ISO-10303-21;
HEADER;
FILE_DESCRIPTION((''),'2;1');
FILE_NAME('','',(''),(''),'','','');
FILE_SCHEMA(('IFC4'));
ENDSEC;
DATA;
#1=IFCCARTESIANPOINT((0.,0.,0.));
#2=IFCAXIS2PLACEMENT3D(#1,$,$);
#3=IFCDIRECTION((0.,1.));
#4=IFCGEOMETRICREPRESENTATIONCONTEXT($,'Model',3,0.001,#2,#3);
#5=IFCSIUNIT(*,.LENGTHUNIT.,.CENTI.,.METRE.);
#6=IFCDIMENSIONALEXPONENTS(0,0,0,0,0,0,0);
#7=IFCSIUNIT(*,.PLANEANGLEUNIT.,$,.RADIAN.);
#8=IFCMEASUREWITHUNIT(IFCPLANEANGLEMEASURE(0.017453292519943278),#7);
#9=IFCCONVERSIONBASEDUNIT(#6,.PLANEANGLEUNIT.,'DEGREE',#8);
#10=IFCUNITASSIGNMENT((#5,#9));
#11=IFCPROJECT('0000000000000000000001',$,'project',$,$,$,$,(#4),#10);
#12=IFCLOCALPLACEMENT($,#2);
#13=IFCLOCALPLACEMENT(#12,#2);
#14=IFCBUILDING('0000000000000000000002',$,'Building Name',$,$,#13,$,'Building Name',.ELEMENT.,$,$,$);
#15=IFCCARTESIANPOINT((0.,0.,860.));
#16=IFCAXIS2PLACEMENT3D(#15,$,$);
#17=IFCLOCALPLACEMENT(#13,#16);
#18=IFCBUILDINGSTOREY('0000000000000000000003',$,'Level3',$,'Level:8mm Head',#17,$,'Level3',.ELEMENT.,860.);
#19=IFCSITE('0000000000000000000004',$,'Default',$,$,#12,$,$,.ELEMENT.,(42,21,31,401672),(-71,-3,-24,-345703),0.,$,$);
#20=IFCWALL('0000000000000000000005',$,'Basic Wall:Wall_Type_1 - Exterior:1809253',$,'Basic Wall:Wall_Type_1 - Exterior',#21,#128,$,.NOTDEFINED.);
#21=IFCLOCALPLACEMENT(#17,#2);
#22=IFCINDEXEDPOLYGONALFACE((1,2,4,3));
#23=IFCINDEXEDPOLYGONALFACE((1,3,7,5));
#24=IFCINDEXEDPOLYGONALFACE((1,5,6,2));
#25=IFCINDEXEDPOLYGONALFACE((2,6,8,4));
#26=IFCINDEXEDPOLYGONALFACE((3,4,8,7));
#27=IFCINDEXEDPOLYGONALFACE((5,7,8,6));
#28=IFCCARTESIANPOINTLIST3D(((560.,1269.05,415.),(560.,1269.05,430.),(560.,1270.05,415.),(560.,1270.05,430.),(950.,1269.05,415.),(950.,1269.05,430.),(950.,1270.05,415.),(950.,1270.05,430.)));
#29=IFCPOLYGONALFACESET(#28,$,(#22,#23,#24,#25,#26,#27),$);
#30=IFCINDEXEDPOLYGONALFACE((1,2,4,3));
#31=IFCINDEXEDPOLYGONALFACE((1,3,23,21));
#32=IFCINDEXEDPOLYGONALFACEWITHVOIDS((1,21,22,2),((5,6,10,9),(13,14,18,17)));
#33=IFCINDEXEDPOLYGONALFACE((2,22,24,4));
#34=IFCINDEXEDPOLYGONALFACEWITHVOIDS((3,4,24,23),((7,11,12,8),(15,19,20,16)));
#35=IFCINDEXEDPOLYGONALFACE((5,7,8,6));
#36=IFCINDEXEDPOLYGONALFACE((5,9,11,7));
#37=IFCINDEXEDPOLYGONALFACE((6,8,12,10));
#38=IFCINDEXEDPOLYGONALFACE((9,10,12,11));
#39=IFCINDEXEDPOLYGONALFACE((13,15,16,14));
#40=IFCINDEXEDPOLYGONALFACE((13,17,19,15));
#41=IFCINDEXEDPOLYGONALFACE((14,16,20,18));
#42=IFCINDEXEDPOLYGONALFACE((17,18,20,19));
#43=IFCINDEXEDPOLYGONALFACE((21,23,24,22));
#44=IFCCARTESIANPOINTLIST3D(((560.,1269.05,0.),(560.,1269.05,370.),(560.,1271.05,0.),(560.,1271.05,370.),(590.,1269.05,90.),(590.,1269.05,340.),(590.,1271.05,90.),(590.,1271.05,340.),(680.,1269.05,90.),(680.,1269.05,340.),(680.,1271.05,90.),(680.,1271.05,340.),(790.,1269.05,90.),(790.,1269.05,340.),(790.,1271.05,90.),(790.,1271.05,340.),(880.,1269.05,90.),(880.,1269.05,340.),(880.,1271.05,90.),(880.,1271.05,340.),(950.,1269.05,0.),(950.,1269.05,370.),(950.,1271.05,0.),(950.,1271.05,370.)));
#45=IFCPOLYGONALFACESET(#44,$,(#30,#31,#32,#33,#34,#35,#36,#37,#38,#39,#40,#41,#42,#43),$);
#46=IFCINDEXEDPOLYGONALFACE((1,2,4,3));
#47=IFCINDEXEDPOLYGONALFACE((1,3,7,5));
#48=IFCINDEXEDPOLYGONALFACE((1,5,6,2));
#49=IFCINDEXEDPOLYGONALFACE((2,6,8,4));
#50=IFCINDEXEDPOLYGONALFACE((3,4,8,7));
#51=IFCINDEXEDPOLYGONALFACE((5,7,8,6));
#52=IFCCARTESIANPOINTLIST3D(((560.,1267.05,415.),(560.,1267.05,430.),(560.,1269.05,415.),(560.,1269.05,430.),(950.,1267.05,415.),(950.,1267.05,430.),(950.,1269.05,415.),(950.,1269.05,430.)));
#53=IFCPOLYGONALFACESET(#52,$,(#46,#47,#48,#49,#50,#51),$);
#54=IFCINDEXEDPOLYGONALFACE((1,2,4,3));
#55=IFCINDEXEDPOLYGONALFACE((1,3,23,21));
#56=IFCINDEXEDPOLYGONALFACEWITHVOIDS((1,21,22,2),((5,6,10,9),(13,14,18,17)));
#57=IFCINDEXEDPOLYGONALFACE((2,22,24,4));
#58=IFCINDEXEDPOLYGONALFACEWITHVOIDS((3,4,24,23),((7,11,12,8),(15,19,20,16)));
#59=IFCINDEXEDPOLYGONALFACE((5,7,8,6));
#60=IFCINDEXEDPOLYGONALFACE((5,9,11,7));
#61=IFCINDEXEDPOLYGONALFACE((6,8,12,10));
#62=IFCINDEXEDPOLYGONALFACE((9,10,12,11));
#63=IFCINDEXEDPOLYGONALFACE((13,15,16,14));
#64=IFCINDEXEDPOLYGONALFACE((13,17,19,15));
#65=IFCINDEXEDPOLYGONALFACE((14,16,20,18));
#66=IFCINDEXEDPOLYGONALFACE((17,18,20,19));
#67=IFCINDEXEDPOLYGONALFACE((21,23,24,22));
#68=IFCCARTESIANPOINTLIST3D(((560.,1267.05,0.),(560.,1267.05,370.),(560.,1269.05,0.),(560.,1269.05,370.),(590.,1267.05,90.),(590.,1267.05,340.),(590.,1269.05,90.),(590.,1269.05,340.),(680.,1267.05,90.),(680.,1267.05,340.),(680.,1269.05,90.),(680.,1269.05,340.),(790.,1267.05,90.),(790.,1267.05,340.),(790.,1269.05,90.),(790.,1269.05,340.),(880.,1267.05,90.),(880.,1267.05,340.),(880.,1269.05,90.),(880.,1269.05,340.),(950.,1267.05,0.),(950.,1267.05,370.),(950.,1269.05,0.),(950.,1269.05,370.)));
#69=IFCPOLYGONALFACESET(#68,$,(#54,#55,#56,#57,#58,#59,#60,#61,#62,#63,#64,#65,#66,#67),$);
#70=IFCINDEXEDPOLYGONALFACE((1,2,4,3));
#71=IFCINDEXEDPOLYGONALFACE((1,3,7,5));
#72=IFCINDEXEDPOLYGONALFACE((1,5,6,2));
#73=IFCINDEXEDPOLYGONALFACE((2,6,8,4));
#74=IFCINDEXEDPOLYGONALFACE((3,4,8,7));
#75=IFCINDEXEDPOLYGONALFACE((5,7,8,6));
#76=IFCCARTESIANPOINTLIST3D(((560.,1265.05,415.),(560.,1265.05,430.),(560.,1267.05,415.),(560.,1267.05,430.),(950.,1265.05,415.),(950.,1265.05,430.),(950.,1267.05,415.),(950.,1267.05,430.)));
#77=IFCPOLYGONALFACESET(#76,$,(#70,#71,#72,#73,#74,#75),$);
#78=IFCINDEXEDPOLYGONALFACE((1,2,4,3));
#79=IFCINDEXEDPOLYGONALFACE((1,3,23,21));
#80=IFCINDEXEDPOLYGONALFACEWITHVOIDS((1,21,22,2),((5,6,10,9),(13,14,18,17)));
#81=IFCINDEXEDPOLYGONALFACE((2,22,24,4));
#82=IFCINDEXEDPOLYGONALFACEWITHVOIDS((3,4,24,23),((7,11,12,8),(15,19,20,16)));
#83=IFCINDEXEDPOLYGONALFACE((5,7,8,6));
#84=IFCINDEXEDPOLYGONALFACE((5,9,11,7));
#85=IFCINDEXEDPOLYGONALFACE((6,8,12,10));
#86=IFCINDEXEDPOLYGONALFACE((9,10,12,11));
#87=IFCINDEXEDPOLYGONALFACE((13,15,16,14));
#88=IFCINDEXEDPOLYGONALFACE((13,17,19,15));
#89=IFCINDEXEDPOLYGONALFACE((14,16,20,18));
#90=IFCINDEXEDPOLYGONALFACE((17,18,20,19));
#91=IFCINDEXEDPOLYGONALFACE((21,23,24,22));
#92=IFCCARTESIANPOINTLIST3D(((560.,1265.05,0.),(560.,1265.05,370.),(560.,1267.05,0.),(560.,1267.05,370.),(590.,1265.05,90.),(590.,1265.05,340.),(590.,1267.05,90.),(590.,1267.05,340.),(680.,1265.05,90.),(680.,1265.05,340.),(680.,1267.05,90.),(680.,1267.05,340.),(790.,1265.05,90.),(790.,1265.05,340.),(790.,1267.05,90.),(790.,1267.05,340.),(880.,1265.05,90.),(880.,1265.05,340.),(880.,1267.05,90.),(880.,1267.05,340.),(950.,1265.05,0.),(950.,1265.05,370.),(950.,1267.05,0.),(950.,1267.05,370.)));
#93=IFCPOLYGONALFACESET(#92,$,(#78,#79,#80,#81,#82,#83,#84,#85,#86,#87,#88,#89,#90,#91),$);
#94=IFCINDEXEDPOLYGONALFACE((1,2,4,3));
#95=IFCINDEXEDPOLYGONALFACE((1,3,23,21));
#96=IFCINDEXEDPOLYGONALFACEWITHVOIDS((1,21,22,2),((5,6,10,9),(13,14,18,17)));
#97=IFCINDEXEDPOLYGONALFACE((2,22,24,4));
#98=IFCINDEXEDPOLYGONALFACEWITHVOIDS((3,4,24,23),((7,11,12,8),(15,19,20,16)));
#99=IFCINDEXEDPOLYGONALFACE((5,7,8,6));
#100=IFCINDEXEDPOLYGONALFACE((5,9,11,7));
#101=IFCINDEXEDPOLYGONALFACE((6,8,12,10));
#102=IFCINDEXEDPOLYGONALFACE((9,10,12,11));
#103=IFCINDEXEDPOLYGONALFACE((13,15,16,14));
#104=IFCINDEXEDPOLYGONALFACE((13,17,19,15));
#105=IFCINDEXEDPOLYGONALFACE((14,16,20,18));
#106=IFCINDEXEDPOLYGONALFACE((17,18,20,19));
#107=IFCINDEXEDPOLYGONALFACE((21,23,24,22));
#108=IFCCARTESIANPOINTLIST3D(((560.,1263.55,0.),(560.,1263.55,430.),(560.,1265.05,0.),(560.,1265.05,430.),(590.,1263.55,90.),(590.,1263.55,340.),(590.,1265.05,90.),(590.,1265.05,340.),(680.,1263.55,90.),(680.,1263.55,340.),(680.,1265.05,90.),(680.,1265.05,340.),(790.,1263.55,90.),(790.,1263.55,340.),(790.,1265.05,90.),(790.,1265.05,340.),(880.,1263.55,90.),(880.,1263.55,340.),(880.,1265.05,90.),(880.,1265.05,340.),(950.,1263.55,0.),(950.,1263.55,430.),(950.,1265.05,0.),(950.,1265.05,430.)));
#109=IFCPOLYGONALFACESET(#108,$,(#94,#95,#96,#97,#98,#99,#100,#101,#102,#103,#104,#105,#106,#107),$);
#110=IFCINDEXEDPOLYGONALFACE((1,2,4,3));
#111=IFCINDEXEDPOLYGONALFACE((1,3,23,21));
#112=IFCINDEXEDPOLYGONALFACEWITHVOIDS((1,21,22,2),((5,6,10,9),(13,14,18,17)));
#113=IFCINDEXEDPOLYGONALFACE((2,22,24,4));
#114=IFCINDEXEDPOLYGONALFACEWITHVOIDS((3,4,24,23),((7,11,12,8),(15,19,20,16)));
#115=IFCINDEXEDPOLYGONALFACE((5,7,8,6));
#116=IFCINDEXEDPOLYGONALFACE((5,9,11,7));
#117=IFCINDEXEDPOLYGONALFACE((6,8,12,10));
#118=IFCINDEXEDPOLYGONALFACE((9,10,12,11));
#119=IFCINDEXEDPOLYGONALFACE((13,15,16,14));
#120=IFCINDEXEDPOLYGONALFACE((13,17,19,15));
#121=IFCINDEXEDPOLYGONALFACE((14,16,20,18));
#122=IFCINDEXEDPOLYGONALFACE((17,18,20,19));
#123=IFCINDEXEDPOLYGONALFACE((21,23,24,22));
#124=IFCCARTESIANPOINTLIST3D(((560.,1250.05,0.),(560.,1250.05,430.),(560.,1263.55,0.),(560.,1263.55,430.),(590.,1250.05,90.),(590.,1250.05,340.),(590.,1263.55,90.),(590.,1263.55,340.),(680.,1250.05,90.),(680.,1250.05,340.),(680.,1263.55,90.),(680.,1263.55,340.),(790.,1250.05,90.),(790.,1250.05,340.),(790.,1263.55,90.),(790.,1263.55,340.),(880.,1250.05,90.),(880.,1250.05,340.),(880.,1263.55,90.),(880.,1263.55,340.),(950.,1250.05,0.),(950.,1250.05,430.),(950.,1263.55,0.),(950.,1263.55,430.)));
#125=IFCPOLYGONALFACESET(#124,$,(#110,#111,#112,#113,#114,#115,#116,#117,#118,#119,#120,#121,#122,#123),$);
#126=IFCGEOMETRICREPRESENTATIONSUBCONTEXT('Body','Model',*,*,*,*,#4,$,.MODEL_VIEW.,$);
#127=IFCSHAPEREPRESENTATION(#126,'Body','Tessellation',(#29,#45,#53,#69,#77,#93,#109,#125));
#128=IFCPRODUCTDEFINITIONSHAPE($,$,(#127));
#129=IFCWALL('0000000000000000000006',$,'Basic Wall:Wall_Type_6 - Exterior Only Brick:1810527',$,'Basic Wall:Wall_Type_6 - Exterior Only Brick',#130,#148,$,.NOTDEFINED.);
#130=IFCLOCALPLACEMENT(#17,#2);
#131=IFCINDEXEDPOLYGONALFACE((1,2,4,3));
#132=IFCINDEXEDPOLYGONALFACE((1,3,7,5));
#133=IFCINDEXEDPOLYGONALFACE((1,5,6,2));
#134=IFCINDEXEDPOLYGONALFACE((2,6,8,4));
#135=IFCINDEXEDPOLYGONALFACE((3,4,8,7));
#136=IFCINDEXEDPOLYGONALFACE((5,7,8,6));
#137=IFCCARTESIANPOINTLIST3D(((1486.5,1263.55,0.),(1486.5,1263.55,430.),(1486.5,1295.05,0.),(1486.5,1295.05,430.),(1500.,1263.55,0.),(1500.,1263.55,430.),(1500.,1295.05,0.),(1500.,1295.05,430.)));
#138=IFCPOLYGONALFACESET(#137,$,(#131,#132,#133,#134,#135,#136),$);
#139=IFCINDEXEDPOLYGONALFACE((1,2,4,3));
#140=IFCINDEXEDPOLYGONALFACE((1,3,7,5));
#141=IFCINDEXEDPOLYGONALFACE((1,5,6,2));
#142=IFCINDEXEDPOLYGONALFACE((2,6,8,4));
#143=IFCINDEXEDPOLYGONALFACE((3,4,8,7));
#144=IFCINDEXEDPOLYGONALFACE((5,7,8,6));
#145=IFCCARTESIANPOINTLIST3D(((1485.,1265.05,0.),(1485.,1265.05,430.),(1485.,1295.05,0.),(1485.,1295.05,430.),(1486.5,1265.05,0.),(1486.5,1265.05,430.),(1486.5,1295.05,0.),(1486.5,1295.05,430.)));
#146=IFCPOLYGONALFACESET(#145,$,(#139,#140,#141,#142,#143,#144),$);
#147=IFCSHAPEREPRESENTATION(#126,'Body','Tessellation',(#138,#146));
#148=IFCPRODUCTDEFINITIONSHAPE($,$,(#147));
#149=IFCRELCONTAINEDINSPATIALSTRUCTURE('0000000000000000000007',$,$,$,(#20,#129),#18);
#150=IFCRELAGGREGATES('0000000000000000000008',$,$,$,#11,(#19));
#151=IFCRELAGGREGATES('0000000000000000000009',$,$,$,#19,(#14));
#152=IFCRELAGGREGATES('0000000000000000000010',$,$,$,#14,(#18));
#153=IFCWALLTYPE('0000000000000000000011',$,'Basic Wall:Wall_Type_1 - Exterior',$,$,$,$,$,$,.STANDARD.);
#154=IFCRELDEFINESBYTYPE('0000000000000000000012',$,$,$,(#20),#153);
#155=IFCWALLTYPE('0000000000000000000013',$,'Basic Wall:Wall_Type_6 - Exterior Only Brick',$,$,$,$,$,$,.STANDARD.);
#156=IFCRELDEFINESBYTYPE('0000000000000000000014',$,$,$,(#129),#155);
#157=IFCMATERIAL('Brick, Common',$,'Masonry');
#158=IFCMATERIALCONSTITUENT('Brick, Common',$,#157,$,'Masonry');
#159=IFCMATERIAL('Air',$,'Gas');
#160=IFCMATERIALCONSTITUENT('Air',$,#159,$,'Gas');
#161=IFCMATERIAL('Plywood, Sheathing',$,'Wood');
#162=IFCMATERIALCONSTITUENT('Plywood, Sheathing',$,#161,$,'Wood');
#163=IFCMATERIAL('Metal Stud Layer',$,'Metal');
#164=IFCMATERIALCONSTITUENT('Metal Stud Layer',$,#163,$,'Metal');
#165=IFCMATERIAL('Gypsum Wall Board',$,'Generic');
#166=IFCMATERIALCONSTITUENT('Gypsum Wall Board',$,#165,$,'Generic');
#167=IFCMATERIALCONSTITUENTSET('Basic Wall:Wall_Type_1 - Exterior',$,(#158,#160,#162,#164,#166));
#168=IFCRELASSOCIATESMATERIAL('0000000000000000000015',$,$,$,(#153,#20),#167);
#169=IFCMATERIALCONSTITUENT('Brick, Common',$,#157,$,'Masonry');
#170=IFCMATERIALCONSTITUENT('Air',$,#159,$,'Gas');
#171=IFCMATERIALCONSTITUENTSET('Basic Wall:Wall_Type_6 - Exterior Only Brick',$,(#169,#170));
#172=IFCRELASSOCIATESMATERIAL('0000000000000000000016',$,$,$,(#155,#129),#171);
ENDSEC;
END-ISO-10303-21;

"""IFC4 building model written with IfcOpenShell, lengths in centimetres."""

from ifc_helpers import new_model, entity, si_unit, converted_unit, direction, frame, origin, place, context, subcontext, project, spatial, indexed_curve, outline, extrude, material, constituent, constituent_set, type_object, element, save


model = new_model("IFC4")

# Units and contexts
model_context = context("Model", 3, precision=0.001, world=origin(), true_north=direction((0.0, 1.0)))
body_context = subcontext(model_context, "Body", "Model", "MODEL_VIEW")
ifc_project = project(units=[si_unit("LENGTHUNIT", "METRE", prefix="CENTI"), converted_unit("PLANEANGLEUNIT", "DEGREE", entity("IfcPlaneAngleMeasure", 0.017453292519943278), si_unit("PLANEANGLEUNIT", "RADIAN"), dimensions=[0, 0, 0, 0, 0, 0, 0])], contexts=[model_context])

# Site, building, storey
site_placement = place(None, origin())
site = spatial("IfcSite", under=ifc_project, at=site_placement, Name="Default", CompositionType="ELEMENT", RefLatitude=(42, 21, 31, 401672), RefLongitude=(-71, -3, -24, -345703), RefElevation=0.0)
building_placement = place(site_placement, origin())
building = spatial("IfcBuilding", under=site, at=building_placement, Name="Building Name", LongName="Building Name", CompositionType="ELEMENT")
storey_placement = place(building_placement, frame((0.0, 0.0, 860.0)))
storey = spatial("IfcBuildingStorey", under=building, at=storey_placement, Name="Level3", ObjectType="Level:8mm Head", LongName="Level3", CompositionType="ELEMENT", Elevation=860.0)

# Shared definitions
ifc_material_1 = material(Name="Brick, Common", Category="Masonry")
ifc_constituent_1 = constituent(ifc_material_1, Name="Brick, Common", Category="Masonry")
ifc_material_2 = material(Name="Air", Category="Gas")
ifc_constituent_2 = constituent(ifc_material_2, Name="Air", Category="Gas")
ifc_material_3 = material(Name="Plywood, Sheathing", Category="Wood")
ifc_constituent_3 = constituent(ifc_material_3, Name="Plywood, Sheathing", Category="Wood")
ifc_material_4 = material(Name="Metal Stud Layer", Category="Metal")
ifc_constituent_4 = constituent(ifc_material_4, Name="Metal Stud Layer", Category="Metal")
ifc_material_5 = material(Name="Gypsum Wall Board", Category="Generic")
ifc_constituent_5 = constituent(ifc_material_5, Name="Gypsum Wall Board", Category="Generic")
ifc_constituent_set_1 = constituent_set(constituents=[ifc_constituent_1, ifc_constituent_2, ifc_constituent_3, ifc_constituent_4, ifc_constituent_5], Name="Basic Wall:Wall_Type_1 - Exterior")
wall_type_1 = type_object("IfcWallType", Name="Basic Wall:Wall_Type_1 - Exterior", PredefinedType="STANDARD", material=ifc_constituent_set_1)

# Wall, openings
wall_1_placement = place(storey_placement, frame((950.0, 1260.55, 0.0), z_axis=(0.0, 0.0, 1.0), x_axis=(-1.0, 0.0, 0.0)))
wall_1 = element("IfcWall", 1, at=wall_1_placement, inside=storey, type_object=wall_type_1, material=ifc_constituent_set_1, Name="Basic Wall:Wall_Type_1 - Exterior:1809253", ObjectType="Basic Wall:Wall_Type_1 - Exterior", PredefinedType="NOTDEFINED", context=body_context, shape_type="SweptSolid", body=[
    extrude(outline(indexed_curve([(-0.5, -7.5), (0.5, -7.5), (0.5, 7.5), (-0.5, 7.5), (-0.5, -7.5)], self_intersect=False)), frame((390.0, -9.0, 422.5), z_axis=(-1.0, 0.0, 0.0), x_axis=(0.0, 1.0, 0.0)), (0.0, 0.0, 1.0), 390.0),
    extrude(outline(indexed_curve([(-185.0, -195.0), (185.0, -195.0), (185.0, 195.0), (-185.0, 195.0), (-185.0, -195.0)], self_intersect=False), holes=[indexed_curve([(155.0, -165.0), (-95.0, -165.0), (-95.0, -75.0), (155.0, -75.0), (155.0, -165.0)], self_intersect=False), indexed_curve([(155.0, 35.0), (-95.0, 35.0), (-95.0, 125.0), (155.0, 125.0), (155.0, 35.0)], self_intersect=False)]), frame((195.0, -8.5, 185.0), z_axis=(0.0, -1.0, 0.0), x_axis=(0.0, 0.0, 1.0)), (0.0, 0.0, 1.0), 2.0),
    extrude(outline(indexed_curve([(-7.5, -1.0), (7.5, -1.0), (7.5, 1.0), (-7.5, 1.0), (-7.5, -1.0)], self_intersect=False)), frame((390.0, -7.5, 422.5), z_axis=(-1.0, 0.0, 0.0), x_axis=(0.0, 0.0, 1.0)), (0.0, 0.0, 1.0), 390.0),
    extrude(outline(indexed_curve([(-185.0, -195.0), (185.0, -195.0), (185.0, 195.0), (-185.0, 195.0), (-185.0, -195.0)], self_intersect=False), holes=[indexed_curve([(155.0, -165.0), (-95.0, -165.0), (-95.0, -75.0), (155.0, -75.0), (155.0, -165.0)], self_intersect=False), indexed_curve([(155.0, 35.0), (-95.0, 35.0), (-95.0, 125.0), (155.0, 125.0), (155.0, 35.0)], self_intersect=False)]), frame((195.0, -6.5, 185.0), z_axis=(0.0, -1.0, 0.0), x_axis=(0.0, 0.0, 1.0)), (0.0, 0.0, 1.0), 2.0),
    extrude(outline(indexed_curve([(-7.5, -1.0), (7.5, -1.0), (7.5, 1.0), (-7.5, 1.0), (-7.5, -1.0)], self_intersect=False)), frame((390.0, -5.5, 422.5), z_axis=(-1.0, 0.0, 0.0), x_axis=(0.0, 0.0, 1.0)), (0.0, 0.0, 1.0), 390.0),
    extrude(outline(indexed_curve([(-185.0, -195.0), (185.0, -195.0), (185.0, 195.0), (-185.0, 195.0), (-185.0, -195.0)], self_intersect=False), holes=[indexed_curve([(155.0, -165.0), (-95.0, -165.0), (-95.0, -75.0), (155.0, -75.0), (155.0, -165.0)], self_intersect=False), indexed_curve([(155.0, 35.0), (-95.0, 35.0), (-95.0, 125.0), (155.0, 125.0), (155.0, 35.0)], self_intersect=False)]), frame((195.0, -4.5, 185.0), z_axis=(0.0, -1.0, 0.0), x_axis=(0.0, 0.0, 1.0)), (0.0, 0.0, 1.0), 2.0),
    extrude(outline(indexed_curve([(-215.0, -195.0), (215.0, -195.0), (215.0, 195.0), (-215.0, 195.0), (-215.0, -195.0)], self_intersect=False), holes=[indexed_curve([(125.0, -165.0), (-125.0, -165.0), (-125.0, -75.0), (125.0, -75.0), (125.0, -165.0)], self_intersect=False), indexed_curve([(125.0, 35.0), (-125.0, 35.0), (-125.0, 125.0), (125.0, 125.0), (125.0, 35.0)], self_intersect=False)]), frame((195.0, -3.0, 215.0), z_axis=(0.0, -1.0, 0.0), x_axis=(0.0, 0.0, 1.0)), (0.0, 0.0, 1.0), 1.5),
    extrude(outline(indexed_curve([(-215.0, -195.0), (215.0, -195.0), (215.0, 195.0), (-215.0, 195.0), (-215.0, -195.0)], self_intersect=False), holes=[indexed_curve([(125.0, 35.0), (-125.0, 35.0), (-125.0, 125.0), (125.0, 125.0), (125.0, 35.0)], self_intersect=False), indexed_curve([(125.0, -165.0), (-125.0, -165.0), (-125.0, -75.0), (125.0, -75.0), (125.0, -165.0)], self_intersect=False)]), frame((195.0, 10.5, 215.0), z_axis=(0.0, -1.0, 0.0), x_axis=(0.0, 0.0, 1.0)), (0.0, 0.0, 1.0), 13.5),
])
opening_1_placement = place(wall_1_placement, frame((360.0, 10.5, 90.0)))
element("IfcOpeningElement", 2, at=opening_1_placement, cuts=wall_1, PredefinedType="OPENING", context=body_context, shape_type="SweptSolid", body=[
    extrude(outline(indexed_curve([(250.0, 90.0), (0.0, 90.0), (0.0, 0.0), (250.0, 0.0), (250.0, 90.0)], self_intersect=False)), frame((0.0, 0.0, 0.0), z_axis=(0.0, -1.0, 0.0), x_axis=(0.0, 0.0, 1.0)), (0.0, 0.0, 1.0), 21.0),
])
opening_2_placement = place(wall_1_placement, frame((950.0, 1260.55, 0.0), z_axis=(0.0, 0.0, 1.0), x_axis=(-1.0, 0.0, 0.0)))
element("IfcOpeningElement", 3, at=opening_2_placement, cuts=wall_1, PredefinedType="OPENING", context=body_context, shape_type="SweptSolid", body=[
    extrude(outline(indexed_curve([(-45.0, -125.0), (45.0, -125.0), (45.0, 125.0), (-45.0, 125.0), (-45.0, -125.0)], self_intersect=False)), frame((635.0, 1402.45, 215.0), z_axis=(0.0, -1.0, 0.0), x_axis=(-1.0, 0.0, 0.0)), (0.0, 0.0, 1.0), 304.8),
])
opening_3_placement = place(wall_1_placement, frame((160.0, 10.5, 90.0)))
element("IfcOpeningElement", 4, at=opening_3_placement, cuts=wall_1, PredefinedType="OPENING", context=body_context, shape_type="SweptSolid", body=[
    extrude(outline(indexed_curve([(250.0, 90.0), (0.0, 90.0), (0.0, 0.0), (250.0, 0.0), (250.0, 90.0)], self_intersect=False)), frame((0.0, 0.0, 0.0), z_axis=(0.0, -1.0, 0.0), x_axis=(0.0, 0.0, 1.0)), (0.0, 0.0, 1.0), 21.0),
])
opening_4_placement = place(wall_1_placement, frame((950.0, 1260.55, 0.0), z_axis=(0.0, 0.0, 1.0), x_axis=(-1.0, 0.0, 0.0)))
element("IfcOpeningElement", 5, at=opening_4_placement, cuts=wall_1, PredefinedType="OPENING", context=body_context, shape_type="SweptSolid", body=[
    extrude(outline(indexed_curve([(-45.0, -125.0), (45.0, -125.0), (45.0, 125.0), (-45.0, 125.0), (-45.0, -125.0)], self_intersect=False)), frame((835.0, 1402.45, 215.0), z_axis=(0.0, -1.0, 0.0), x_axis=(-1.0, 0.0, 0.0)), (0.0, 0.0, 1.0), 304.8),
])

# Wall
ifc_constituent_6 = constituent(ifc_material_1, Name="Brick, Common", Category="Masonry")
ifc_constituent_7 = constituent(ifc_material_2, Name="Air", Category="Gas")
ifc_constituent_set_2 = constituent_set(constituents=[ifc_constituent_6, ifc_constituent_7], Name="Basic Wall:Wall_Type_6 - Exterior Only Brick")
wall_type_2 = type_object("IfcWallType", Name="Basic Wall:Wall_Type_6 - Exterior Only Brick", PredefinedType="STANDARD", material=ifc_constituent_set_2)
wall_2_placement = place(storey_placement, frame((1492.5, 1265.05, 0.0), z_axis=(0.0, 0.0, 1.0), x_axis=(0.0, 1.0, 0.0)))
element("IfcWall", 6, at=wall_2_placement, inside=storey, type_object=wall_type_2, material=ifc_constituent_set_2, Name="Basic Wall:Wall_Type_6 - Exterior Only Brick:1810527", ObjectType="Basic Wall:Wall_Type_6 - Exterior Only Brick", PredefinedType="NOTDEFINED", context=body_context, shape_type="SweptSolid", body=[
    extrude(outline(indexed_curve([(-6.75, -15.75), (6.75, -15.75), (6.75, 15.75), (-6.75, 15.75), (-6.75, -15.75)], self_intersect=False)), frame((14.25, -0.75, 0.0), z_axis=(0.0, 0.0, 1.0), x_axis=(0.0, 1.0, 0.0)), (0.0, 0.0, 1.0), 430.0),
    extrude(outline(indexed_curve([(-0.75, -15.0), (0.75, -15.0), (0.75, 15.0), (-0.75, 15.0), (-0.75, -15.0)], self_intersect=False)), frame((15.0, 6.75, 0.0), z_axis=(0.0, 0.0, 1.0), x_axis=(0.0, -1.0, 0.0)), (0.0, 0.0, 1.0), 430.0),
])

save(model, "model.ifc")
